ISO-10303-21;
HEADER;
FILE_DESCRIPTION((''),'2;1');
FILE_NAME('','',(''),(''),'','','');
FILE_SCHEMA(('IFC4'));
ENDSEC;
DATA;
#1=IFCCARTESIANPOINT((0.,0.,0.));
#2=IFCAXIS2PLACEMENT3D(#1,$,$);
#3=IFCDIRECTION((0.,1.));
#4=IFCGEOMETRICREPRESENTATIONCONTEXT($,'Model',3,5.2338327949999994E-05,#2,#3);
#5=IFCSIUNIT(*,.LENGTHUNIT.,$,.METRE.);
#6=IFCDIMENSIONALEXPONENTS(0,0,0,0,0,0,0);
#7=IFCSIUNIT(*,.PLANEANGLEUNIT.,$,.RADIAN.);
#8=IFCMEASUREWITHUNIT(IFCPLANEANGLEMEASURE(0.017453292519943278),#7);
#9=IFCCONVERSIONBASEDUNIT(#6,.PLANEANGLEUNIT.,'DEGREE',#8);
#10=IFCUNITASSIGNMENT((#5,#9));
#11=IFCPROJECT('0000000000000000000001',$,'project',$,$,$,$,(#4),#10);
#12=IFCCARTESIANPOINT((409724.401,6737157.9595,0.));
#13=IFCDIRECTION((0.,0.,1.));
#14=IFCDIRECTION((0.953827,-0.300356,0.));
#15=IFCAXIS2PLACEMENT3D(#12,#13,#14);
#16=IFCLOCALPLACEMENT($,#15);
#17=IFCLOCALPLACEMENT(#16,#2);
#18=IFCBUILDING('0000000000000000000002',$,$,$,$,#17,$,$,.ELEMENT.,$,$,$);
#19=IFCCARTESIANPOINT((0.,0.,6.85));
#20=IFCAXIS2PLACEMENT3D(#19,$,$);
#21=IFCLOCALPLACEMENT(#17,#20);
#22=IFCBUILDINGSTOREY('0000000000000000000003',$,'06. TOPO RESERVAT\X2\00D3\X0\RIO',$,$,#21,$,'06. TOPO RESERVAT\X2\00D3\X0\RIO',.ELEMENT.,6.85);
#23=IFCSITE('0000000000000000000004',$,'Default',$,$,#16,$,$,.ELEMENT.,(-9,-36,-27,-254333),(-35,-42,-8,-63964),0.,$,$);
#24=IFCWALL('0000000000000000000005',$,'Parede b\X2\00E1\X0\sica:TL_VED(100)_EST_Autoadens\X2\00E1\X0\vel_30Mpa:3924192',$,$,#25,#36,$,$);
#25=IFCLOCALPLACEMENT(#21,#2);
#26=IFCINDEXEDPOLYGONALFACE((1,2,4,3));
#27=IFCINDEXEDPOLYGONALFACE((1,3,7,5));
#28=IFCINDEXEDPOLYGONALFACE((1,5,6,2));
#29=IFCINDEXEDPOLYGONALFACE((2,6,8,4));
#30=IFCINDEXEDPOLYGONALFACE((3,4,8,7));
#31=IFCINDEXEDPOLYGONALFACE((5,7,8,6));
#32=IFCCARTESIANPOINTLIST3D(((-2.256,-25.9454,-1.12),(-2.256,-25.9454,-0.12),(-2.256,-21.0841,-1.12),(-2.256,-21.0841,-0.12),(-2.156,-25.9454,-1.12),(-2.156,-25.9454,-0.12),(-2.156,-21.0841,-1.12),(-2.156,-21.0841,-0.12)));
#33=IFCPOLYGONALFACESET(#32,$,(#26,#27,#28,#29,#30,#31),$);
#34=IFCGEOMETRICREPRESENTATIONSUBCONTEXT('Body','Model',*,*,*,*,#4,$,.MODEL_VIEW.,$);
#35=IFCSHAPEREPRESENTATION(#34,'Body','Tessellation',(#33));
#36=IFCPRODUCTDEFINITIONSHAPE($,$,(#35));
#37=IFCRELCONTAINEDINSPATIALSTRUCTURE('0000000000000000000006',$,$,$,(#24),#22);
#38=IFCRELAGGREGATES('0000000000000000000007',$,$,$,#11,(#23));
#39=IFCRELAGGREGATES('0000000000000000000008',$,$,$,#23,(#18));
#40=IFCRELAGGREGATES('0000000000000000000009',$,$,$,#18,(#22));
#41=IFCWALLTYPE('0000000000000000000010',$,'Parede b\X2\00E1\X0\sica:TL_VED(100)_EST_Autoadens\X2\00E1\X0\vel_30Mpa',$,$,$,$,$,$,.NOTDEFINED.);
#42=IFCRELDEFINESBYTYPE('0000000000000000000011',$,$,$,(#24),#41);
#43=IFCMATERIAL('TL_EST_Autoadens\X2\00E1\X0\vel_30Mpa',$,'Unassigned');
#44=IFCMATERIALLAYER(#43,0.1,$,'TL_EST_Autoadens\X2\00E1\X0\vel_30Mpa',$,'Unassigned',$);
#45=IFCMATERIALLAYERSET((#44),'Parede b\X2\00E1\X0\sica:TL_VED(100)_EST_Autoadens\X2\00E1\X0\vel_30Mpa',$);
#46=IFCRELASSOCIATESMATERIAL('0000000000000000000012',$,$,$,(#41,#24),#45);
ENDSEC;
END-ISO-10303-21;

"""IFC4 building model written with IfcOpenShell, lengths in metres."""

from ifc_helpers import new_model, entity, si_unit, converted_unit, direction, frame, frame_2d, origin, place, context, subcontext, project, spatial, rectangle, extrude, material, layer, layer_set, layer_usage, type_object, element, save


model = new_model("IFC4")

# Units and contexts
model_context = context("Model", 3, precision=5.2338327949999994e-05, world=origin(), true_north=direction((0.0, 1.0)))
body_context = subcontext(model_context, "Body", "Model", "MODEL_VIEW")
ifc_project = project(units=[si_unit("LENGTHUNIT", "METRE"), converted_unit("PLANEANGLEUNIT", "DEGREE", entity("IfcPlaneAngleMeasure", 0.017453292519943278), si_unit("PLANEANGLEUNIT", "RADIAN"), dimensions=[0, 0, 0, 0, 0, 0, 0])], contexts=[model_context])

# Site, building, storey
site_placement = place(None, frame((409724.401, 6737157.9595, 0.0), z_axis=(0.0, 0.0, 1.0), x_axis=(0.953827, -0.300356, 0.0)))
site = spatial("IfcSite", under=ifc_project, at=site_placement, Name="Default", CompositionType="ELEMENT", RefLatitude=(-9, -36, -27, -254333), RefLongitude=(-35, -42, -8, -63964), RefElevation=0.0)
building_placement = place(site_placement, origin())
building = spatial("IfcBuilding", under=site, at=building_placement, CompositionType="ELEMENT")
storey_placement = place(building_placement, frame((0.0, 0.0, 6.85)))
storey = spatial("IfcBuildingStorey", under=building, at=storey_placement, Name="06. TOPO RESERVATÓRIO", LongName="06. TOPO RESERVATÓRIO", CompositionType="ELEMENT", Elevation=6.85)

# Wall
ifc_material_1 = material(Name="TL_EST_Autoadensável_30Mpa", Category="Unassigned")
ifc_layer = layer(ifc_material_1, 0.1, Name="TL_EST_Autoadensável_30Mpa", Category="Unassigned")
ifc_layer_set = layer_set([ifc_layer], Name="Parede básica:TL_VED(100)_EST_Autoadensável_30Mpa")
ifc_layer_usage = layer_usage(ifc_layer_set, "AXIS2", "NEGATIVE", 0.05)
wall_type = type_object("IfcWallType", Name="Parede básica:TL_VED(100)_EST_Autoadensável_30Mpa", PredefinedType="NOTDEFINED", material=ifc_layer_set)
wall_placement = place(storey_placement, frame((-2.206, -21.0841, -1.12), z_axis=(0.0, 0.0, 1.0), x_axis=(0.0, -1.0, 0.0)))
element("IfcWall", 1, at=wall_placement, inside=storey, type_object=wall_type, material=ifc_layer_usage, Name="Parede básica:TL_VED(100)_EST_Autoadensável_30Mpa:3924192", context=body_context, shape_type="SweptSolid", body=[
    extrude(rectangle(XDim=4.8613, YDim=0.1, at=frame_2d((2.4306, 0.0), x_axis=(-1.0, 0.0))), origin(), (0.0, 0.0, 1.0), 1.0),
])

save(model, "model.ifc")
